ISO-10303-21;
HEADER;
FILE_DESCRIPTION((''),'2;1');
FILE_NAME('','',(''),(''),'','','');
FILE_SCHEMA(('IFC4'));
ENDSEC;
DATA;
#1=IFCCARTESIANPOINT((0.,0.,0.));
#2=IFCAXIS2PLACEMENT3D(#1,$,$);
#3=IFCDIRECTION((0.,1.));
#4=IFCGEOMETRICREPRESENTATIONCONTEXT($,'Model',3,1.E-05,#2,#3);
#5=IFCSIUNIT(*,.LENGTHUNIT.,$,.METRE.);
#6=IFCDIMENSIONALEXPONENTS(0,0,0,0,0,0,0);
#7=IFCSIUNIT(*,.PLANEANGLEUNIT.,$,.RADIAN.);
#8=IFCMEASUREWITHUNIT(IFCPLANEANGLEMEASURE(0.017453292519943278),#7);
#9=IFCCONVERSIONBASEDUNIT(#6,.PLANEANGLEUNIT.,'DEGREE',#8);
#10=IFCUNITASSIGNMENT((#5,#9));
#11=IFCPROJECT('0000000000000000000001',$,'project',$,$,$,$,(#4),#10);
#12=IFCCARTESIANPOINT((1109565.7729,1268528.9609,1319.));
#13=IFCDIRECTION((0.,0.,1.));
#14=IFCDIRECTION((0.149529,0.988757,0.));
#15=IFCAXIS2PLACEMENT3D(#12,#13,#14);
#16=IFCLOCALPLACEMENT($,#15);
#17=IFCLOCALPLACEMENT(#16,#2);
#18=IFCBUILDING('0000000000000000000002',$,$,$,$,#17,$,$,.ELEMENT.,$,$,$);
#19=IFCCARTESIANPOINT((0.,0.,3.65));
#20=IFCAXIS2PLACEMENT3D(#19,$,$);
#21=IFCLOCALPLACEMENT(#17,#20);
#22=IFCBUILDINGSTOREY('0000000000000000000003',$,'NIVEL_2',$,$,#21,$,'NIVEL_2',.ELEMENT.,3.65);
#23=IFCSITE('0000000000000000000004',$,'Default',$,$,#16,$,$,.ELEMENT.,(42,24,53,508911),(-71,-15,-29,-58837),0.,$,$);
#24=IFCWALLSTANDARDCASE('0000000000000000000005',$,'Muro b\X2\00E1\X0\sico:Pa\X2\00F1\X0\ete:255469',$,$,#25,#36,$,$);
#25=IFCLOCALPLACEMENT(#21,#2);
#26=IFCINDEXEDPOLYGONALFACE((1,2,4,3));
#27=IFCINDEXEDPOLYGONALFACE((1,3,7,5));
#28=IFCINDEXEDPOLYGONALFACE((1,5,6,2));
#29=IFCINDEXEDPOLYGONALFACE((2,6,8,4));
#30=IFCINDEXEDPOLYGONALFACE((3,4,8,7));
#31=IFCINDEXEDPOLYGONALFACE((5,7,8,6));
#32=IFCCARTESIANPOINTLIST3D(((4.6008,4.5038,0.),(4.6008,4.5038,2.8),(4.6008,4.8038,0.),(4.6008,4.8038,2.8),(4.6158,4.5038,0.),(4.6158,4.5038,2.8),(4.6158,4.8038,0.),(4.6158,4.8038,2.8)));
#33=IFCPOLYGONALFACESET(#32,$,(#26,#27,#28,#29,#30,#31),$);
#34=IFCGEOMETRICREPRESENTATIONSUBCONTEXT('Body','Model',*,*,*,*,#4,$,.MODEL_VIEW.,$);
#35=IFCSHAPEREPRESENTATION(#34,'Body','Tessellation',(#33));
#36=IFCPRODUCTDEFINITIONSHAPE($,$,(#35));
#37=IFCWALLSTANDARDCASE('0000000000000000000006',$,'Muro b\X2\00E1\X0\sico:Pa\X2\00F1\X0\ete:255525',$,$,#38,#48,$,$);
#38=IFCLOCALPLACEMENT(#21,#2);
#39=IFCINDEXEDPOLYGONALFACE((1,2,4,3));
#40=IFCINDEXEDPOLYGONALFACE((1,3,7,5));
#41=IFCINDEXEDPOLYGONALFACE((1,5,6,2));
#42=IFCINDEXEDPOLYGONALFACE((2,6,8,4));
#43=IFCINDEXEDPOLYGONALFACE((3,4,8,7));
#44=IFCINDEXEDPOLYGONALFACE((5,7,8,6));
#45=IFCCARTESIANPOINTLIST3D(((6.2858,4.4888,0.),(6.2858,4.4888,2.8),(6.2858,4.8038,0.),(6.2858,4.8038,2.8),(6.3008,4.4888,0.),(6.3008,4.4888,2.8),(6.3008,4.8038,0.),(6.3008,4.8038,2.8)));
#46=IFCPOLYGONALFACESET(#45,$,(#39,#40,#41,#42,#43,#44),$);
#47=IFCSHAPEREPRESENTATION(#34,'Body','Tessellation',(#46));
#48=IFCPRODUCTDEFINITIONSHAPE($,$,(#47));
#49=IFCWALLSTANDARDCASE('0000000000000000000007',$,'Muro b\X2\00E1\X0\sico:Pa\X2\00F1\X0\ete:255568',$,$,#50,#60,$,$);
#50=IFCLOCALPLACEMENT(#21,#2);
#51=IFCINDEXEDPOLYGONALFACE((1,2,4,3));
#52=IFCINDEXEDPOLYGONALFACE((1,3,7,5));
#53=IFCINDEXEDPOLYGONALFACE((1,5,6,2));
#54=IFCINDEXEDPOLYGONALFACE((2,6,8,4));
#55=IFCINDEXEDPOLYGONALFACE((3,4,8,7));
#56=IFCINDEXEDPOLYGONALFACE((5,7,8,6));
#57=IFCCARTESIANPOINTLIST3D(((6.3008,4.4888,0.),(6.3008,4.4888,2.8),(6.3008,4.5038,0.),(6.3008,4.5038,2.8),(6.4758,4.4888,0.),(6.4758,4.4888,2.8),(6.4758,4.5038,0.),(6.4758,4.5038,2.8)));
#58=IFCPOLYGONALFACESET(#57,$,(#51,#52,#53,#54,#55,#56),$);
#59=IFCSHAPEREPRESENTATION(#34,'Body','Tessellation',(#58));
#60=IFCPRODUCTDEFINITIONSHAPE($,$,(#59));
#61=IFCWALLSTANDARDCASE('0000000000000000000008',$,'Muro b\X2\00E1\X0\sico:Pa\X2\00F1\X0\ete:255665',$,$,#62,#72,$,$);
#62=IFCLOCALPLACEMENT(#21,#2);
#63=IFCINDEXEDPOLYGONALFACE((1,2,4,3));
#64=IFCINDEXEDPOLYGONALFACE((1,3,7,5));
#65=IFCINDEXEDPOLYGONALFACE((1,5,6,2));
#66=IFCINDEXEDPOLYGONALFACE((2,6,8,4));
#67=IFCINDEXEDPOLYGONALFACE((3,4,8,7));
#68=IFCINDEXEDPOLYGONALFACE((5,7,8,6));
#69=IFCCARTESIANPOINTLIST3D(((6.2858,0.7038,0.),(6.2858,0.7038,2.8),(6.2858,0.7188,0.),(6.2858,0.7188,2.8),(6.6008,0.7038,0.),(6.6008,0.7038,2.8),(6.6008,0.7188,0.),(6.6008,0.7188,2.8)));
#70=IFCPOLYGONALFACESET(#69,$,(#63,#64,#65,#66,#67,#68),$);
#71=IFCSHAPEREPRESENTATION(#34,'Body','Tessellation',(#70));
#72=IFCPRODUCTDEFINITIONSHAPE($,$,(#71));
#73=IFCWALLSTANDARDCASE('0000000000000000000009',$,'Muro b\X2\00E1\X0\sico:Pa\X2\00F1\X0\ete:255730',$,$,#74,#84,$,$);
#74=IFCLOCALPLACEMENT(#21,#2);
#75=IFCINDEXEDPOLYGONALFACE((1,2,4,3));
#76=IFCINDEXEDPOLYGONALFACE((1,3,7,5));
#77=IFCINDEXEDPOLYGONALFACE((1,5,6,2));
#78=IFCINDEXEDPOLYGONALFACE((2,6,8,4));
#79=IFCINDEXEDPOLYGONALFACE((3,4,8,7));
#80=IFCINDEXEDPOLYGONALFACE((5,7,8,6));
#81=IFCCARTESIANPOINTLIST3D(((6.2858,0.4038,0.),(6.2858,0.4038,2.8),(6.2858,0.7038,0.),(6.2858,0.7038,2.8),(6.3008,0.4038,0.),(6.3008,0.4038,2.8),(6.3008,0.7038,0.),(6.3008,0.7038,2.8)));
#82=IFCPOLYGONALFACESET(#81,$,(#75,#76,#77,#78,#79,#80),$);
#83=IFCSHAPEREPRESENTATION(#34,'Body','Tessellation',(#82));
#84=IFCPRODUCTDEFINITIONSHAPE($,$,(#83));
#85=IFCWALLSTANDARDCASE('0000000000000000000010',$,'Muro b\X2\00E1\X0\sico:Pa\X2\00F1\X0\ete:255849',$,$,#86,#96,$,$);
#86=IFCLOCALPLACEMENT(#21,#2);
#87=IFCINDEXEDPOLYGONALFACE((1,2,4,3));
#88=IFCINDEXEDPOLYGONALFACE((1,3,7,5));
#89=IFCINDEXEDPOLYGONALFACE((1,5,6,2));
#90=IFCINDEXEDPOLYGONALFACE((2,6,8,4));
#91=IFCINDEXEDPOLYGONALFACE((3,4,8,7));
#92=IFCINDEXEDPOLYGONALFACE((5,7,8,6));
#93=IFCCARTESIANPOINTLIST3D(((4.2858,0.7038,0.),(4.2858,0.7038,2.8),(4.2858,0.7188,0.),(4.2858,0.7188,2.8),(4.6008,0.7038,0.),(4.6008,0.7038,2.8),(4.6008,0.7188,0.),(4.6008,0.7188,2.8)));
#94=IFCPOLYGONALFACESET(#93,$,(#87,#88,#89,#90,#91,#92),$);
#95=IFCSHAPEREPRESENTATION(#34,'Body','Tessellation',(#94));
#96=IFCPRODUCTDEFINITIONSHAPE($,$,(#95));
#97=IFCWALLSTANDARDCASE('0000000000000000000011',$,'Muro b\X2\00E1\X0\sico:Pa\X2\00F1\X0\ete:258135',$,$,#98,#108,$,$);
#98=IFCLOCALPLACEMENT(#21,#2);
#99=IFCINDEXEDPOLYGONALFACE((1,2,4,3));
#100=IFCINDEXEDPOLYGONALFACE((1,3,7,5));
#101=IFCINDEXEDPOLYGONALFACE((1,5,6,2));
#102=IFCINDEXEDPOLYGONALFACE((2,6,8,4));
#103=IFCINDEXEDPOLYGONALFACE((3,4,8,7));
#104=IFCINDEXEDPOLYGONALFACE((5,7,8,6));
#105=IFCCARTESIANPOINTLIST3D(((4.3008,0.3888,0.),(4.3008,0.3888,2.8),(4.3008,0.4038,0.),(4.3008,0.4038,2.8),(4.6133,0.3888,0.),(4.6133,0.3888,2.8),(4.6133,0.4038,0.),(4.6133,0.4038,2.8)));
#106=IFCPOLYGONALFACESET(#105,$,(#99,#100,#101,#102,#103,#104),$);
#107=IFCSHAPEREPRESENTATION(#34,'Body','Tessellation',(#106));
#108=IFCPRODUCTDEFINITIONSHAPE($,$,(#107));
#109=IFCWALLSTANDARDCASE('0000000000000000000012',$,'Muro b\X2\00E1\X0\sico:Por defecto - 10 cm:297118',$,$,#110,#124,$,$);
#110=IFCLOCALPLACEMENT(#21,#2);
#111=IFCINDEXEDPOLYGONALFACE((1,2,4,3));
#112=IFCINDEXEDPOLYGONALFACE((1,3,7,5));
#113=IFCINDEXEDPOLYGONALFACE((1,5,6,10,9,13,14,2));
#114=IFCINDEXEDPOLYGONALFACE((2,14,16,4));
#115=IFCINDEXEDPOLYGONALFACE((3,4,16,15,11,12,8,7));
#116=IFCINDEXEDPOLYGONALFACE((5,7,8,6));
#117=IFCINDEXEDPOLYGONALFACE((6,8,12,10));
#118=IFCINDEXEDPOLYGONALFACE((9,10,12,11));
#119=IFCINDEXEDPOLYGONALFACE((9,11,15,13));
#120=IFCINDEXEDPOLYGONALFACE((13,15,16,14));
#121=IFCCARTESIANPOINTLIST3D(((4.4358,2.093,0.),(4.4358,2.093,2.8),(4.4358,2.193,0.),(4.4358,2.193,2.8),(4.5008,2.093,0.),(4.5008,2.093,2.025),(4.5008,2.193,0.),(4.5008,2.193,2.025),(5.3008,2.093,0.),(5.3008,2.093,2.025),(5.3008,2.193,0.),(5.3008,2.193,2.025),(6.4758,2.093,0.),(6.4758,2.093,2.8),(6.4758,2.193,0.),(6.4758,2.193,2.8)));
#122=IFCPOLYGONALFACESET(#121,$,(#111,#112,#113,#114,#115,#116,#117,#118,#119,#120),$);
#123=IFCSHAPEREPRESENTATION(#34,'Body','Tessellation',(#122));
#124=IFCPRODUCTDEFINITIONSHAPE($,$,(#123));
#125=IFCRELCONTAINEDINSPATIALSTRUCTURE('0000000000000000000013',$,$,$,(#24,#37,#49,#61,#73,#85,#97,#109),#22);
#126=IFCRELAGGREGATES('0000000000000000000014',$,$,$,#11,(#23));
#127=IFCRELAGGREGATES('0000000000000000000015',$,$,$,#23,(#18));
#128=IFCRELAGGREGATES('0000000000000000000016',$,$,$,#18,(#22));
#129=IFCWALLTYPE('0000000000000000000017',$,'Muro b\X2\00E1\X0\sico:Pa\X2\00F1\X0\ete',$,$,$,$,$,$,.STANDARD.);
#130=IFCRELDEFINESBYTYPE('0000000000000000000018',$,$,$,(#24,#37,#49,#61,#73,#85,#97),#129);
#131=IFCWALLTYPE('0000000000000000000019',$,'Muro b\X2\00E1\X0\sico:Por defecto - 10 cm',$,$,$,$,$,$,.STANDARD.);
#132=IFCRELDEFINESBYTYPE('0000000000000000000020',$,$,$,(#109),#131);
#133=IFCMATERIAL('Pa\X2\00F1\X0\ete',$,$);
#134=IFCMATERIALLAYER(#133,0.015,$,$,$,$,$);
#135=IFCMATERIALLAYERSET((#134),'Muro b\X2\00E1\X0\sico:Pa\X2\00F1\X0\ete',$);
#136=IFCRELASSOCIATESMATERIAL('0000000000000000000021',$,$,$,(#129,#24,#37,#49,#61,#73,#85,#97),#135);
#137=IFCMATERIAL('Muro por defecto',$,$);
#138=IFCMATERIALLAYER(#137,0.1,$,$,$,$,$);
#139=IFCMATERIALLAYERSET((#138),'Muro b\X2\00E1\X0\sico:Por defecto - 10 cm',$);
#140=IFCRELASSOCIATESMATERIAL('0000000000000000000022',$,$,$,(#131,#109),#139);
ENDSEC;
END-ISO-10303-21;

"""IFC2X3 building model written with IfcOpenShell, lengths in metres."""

from ifc_helpers import new_model, entity, si_unit, converted_unit, direction, frame, frame_2d, origin, place, context, subcontext, project, spatial, rectangle, extrude, material, layer, layer_set, layer_usage, type_object, element, save


model = new_model("IFC2X3")

# Units and contexts
model_context = context("Model", 3, precision=1e-05, world=origin(), true_north=direction((0.0, 1.0)))
body_context = subcontext(model_context, "Body", "Model", "MODEL_VIEW")
ifc_project = project(units=[si_unit("LENGTHUNIT", "METRE"), converted_unit("PLANEANGLEUNIT", "DEGREE", entity("IfcPlaneAngleMeasure", 0.017453292519943278), si_unit("PLANEANGLEUNIT", "RADIAN"), dimensions=[0, 0, 0, 0, 0, 0, 0])], contexts=[model_context])

# Site, building, storey
site_placement = place(None, frame((1109565.7729, 1268528.9609, 1319.0), z_axis=(0.0, 0.0, 1.0), x_axis=(0.149529, 0.988757, 0.0)))
site = spatial("IfcSite", under=ifc_project, at=site_placement, Name="Default", CompositionType="ELEMENT", RefLatitude=(42, 24, 53, 508911), RefLongitude=(-71, -15, -29, -58837), RefElevation=0.0)
building_placement = place(site_placement, origin())
building = spatial("IfcBuilding", under=site, at=building_placement, CompositionType="ELEMENT")
storey_placement = place(building_placement, frame((0.0, 0.0, 3.65)))
storey = spatial("IfcBuildingStorey", under=building, at=storey_placement, Name="NIVEL_2", LongName="NIVEL_2", CompositionType="ELEMENT", Elevation=3.65)

# Shared definitions
ifc_material_1 = material(Name="Pañete")

# Walls
ifc_layer_1 = layer(ifc_material_1, 0.015)
ifc_layer_set_1 = layer_set([ifc_layer_1], Name="Muro básico:Pañete")
wall_type_1 = type_object("IfcWallType", Name="Muro básico:Pañete", PredefinedType="STANDARD", material=ifc_layer_set_1)
ifc_layer_usage_1 = layer_usage(ifc_layer_set_1, "AXIS2", "POSITIVE", -0.0075)
wall_1_placement = place(storey_placement, frame((4.6083, 4.5038, 0.0), z_axis=(0.0, 0.0, 1.0), x_axis=(0.0, 1.0, 0.0)))
element("IfcWallStandardCase", 1, at=wall_1_placement, inside=storey, type_object=wall_type_1, material=ifc_layer_usage_1, Name="Muro básico:Pañete:255469", context=body_context, shape_type="SweptSolid", body=[
    extrude(rectangle(XDim=0.3, YDim=0.015, at=frame_2d((0.15, 0.0), x_axis=(-1.0, 0.0))), origin(), (0.0, 0.0, 1.0), 2.8),
])
ifc_layer_usage_2 = layer_usage(ifc_layer_set_1, "AXIS2", "POSITIVE", -0.0075)
wall_2_placement = place(storey_placement, frame((6.2933, 4.8038, 0.0), z_axis=(0.0, 0.0, 1.0), x_axis=(0.0, -1.0, 0.0)))
element("IfcWallStandardCase", 2, at=wall_2_placement, inside=storey, type_object=wall_type_1, material=ifc_layer_usage_2, Name="Muro básico:Pañete:255525", context=body_context, shape_type="SweptSolid", body=[
    extrude(rectangle(XDim=0.315, YDim=0.015, at=frame_2d((0.1575, 0.0), x_axis=(-1.0, 0.0))), origin(), (0.0, 0.0, 1.0), 2.8),
])
ifc_layer_usage_3 = layer_usage(ifc_layer_set_1, "AXIS2", "POSITIVE", -0.0075)
wall_3_placement = place(storey_placement, frame((6.3008, 4.4963, 0.0)))
element("IfcWallStandardCase", 3, at=wall_3_placement, inside=storey, type_object=wall_type_1, material=ifc_layer_usage_3, Name="Muro básico:Pañete:255568", context=body_context, shape_type="SweptSolid", body=[
    extrude(rectangle(XDim=0.175, YDim=0.015, at=frame_2d((0.0875, 0.0), x_axis=(-1.0, 0.0))), origin(), (0.0, 0.0, 1.0), 2.8),
])
ifc_layer_usage_4 = layer_usage(ifc_layer_set_1, "AXIS2", "POSITIVE", -0.0075)
wall_4_placement = place(storey_placement, frame((6.6008, 0.7113, 0.0), z_axis=(0.0, 0.0, 1.0), x_axis=(-1.0, 0.0, 0.0)))
element("IfcWallStandardCase", 4, at=wall_4_placement, inside=storey, type_object=wall_type_1, material=ifc_layer_usage_4, Name="Muro básico:Pañete:255665", context=body_context, shape_type="SweptSolid", body=[
    extrude(rectangle(XDim=0.315, YDim=0.015, at=frame_2d((0.1575, 0.0), x_axis=(-1.0, 0.0))), origin(), (0.0, 0.0, 1.0), 2.8),
])
ifc_layer_usage_5 = layer_usage(ifc_layer_set_1, "AXIS2", "POSITIVE", -0.0075)
wall_5_placement = place(storey_placement, frame((6.2933, 0.7038, 0.0), z_axis=(0.0, 0.0, 1.0), x_axis=(0.0, -1.0, 0.0)))
element("IfcWallStandardCase", 5, at=wall_5_placement, inside=storey, type_object=wall_type_1, material=ifc_layer_usage_5, Name="Muro básico:Pañete:255730", context=body_context, shape_type="SweptSolid", body=[
    extrude(rectangle(XDim=0.3, YDim=0.015, at=frame_2d((0.15, 0.0), x_axis=(-1.0, 0.0))), origin(), (0.0, 0.0, 1.0), 2.8),
])
ifc_layer_usage_6 = layer_usage(ifc_layer_set_1, "AXIS2", "POSITIVE", -0.0075)
wall_6_placement = place(storey_placement, frame((4.6008, 0.7113, 0.0), z_axis=(0.0, 0.0, 1.0), x_axis=(-1.0, 0.0, 0.0)))
element("IfcWallStandardCase", 6, at=wall_6_placement, inside=storey, type_object=wall_type_1, material=ifc_layer_usage_6, Name="Muro básico:Pañete:255849", context=body_context, shape_type="SweptSolid", body=[
    extrude(rectangle(XDim=0.315, YDim=0.015, at=frame_2d((0.1575, 0.0), x_axis=(-1.0, 0.0))), origin(), (0.0, 0.0, 1.0), 2.8),
])
ifc_layer_usage_7 = layer_usage(ifc_layer_set_1, "AXIS2", "POSITIVE", -0.0075)
wall_7_placement = place(storey_placement, frame((4.3008, 0.3963, 0.0)))
element("IfcWallStandardCase", 7, at=wall_7_placement, inside=storey, type_object=wall_type_1, material=ifc_layer_usage_7, Name="Muro básico:Pañete:258135", context=body_context, shape_type="SweptSolid", body=[
    extrude(rectangle(XDim=0.3125, YDim=0.015, at=frame_2d((0.1562, 0.0), x_axis=(-1.0, 0.0))), origin(), (0.0, 0.0, 1.0), 2.8),
])

# Wall, opening
ifc_material_2 = material(Name="Muro por defecto")
ifc_layer_2 = layer(ifc_material_2, 0.1)
ifc_layer_set_2 = layer_set([ifc_layer_2], Name="Muro básico:Por defecto - 10 cm")
ifc_layer_usage_8 = layer_usage(ifc_layer_set_2, "AXIS2", "POSITIVE", -0.05)
wall_type_2 = type_object("IfcWallType", Name="Muro básico:Por defecto - 10 cm", PredefinedType="STANDARD", material=ifc_layer_set_2)
wall_8_placement = place(storey_placement, frame((6.4758, 2.143, 0.0), z_axis=(0.0, 0.0, 1.0), x_axis=(-1.0, 0.0, 0.0)))
wall_8 = element("IfcWallStandardCase", 8, at=wall_8_placement, inside=storey, type_object=wall_type_2, material=ifc_layer_usage_8, Name="Muro básico:Por defecto - 10 cm:297118", context=body_context, shape_type="SweptSolid", body=[
    extrude(rectangle(XDim=2.04, YDim=0.1, at=frame_2d((1.02, 0.0), x_axis=(-1.0, 0.0))), origin(), (0.0, 0.0, 1.0), 2.8),
])
opening_1_placement = place(wall_8_placement, frame((1.975, 0.05, 0.0)))
element("IfcOpeningElement", 9, at=opening_1_placement, cuts=wall_8, ObjectType="Opening", context=body_context, shape_type="SweptSolid", body=[
    extrude(rectangle(XDim=2.025, YDim=0.8, at=frame_2d((1.0125, 0.4), x_axis=(1.0, 0.0))), frame((0.0, 0.0, 0.0), z_axis=(0.0, -1.0, 0.0), x_axis=(0.0, 0.0, 1.0)), (0.0, 0.0, 1.0), 0.1),
])

save(model, "model.ifc")
